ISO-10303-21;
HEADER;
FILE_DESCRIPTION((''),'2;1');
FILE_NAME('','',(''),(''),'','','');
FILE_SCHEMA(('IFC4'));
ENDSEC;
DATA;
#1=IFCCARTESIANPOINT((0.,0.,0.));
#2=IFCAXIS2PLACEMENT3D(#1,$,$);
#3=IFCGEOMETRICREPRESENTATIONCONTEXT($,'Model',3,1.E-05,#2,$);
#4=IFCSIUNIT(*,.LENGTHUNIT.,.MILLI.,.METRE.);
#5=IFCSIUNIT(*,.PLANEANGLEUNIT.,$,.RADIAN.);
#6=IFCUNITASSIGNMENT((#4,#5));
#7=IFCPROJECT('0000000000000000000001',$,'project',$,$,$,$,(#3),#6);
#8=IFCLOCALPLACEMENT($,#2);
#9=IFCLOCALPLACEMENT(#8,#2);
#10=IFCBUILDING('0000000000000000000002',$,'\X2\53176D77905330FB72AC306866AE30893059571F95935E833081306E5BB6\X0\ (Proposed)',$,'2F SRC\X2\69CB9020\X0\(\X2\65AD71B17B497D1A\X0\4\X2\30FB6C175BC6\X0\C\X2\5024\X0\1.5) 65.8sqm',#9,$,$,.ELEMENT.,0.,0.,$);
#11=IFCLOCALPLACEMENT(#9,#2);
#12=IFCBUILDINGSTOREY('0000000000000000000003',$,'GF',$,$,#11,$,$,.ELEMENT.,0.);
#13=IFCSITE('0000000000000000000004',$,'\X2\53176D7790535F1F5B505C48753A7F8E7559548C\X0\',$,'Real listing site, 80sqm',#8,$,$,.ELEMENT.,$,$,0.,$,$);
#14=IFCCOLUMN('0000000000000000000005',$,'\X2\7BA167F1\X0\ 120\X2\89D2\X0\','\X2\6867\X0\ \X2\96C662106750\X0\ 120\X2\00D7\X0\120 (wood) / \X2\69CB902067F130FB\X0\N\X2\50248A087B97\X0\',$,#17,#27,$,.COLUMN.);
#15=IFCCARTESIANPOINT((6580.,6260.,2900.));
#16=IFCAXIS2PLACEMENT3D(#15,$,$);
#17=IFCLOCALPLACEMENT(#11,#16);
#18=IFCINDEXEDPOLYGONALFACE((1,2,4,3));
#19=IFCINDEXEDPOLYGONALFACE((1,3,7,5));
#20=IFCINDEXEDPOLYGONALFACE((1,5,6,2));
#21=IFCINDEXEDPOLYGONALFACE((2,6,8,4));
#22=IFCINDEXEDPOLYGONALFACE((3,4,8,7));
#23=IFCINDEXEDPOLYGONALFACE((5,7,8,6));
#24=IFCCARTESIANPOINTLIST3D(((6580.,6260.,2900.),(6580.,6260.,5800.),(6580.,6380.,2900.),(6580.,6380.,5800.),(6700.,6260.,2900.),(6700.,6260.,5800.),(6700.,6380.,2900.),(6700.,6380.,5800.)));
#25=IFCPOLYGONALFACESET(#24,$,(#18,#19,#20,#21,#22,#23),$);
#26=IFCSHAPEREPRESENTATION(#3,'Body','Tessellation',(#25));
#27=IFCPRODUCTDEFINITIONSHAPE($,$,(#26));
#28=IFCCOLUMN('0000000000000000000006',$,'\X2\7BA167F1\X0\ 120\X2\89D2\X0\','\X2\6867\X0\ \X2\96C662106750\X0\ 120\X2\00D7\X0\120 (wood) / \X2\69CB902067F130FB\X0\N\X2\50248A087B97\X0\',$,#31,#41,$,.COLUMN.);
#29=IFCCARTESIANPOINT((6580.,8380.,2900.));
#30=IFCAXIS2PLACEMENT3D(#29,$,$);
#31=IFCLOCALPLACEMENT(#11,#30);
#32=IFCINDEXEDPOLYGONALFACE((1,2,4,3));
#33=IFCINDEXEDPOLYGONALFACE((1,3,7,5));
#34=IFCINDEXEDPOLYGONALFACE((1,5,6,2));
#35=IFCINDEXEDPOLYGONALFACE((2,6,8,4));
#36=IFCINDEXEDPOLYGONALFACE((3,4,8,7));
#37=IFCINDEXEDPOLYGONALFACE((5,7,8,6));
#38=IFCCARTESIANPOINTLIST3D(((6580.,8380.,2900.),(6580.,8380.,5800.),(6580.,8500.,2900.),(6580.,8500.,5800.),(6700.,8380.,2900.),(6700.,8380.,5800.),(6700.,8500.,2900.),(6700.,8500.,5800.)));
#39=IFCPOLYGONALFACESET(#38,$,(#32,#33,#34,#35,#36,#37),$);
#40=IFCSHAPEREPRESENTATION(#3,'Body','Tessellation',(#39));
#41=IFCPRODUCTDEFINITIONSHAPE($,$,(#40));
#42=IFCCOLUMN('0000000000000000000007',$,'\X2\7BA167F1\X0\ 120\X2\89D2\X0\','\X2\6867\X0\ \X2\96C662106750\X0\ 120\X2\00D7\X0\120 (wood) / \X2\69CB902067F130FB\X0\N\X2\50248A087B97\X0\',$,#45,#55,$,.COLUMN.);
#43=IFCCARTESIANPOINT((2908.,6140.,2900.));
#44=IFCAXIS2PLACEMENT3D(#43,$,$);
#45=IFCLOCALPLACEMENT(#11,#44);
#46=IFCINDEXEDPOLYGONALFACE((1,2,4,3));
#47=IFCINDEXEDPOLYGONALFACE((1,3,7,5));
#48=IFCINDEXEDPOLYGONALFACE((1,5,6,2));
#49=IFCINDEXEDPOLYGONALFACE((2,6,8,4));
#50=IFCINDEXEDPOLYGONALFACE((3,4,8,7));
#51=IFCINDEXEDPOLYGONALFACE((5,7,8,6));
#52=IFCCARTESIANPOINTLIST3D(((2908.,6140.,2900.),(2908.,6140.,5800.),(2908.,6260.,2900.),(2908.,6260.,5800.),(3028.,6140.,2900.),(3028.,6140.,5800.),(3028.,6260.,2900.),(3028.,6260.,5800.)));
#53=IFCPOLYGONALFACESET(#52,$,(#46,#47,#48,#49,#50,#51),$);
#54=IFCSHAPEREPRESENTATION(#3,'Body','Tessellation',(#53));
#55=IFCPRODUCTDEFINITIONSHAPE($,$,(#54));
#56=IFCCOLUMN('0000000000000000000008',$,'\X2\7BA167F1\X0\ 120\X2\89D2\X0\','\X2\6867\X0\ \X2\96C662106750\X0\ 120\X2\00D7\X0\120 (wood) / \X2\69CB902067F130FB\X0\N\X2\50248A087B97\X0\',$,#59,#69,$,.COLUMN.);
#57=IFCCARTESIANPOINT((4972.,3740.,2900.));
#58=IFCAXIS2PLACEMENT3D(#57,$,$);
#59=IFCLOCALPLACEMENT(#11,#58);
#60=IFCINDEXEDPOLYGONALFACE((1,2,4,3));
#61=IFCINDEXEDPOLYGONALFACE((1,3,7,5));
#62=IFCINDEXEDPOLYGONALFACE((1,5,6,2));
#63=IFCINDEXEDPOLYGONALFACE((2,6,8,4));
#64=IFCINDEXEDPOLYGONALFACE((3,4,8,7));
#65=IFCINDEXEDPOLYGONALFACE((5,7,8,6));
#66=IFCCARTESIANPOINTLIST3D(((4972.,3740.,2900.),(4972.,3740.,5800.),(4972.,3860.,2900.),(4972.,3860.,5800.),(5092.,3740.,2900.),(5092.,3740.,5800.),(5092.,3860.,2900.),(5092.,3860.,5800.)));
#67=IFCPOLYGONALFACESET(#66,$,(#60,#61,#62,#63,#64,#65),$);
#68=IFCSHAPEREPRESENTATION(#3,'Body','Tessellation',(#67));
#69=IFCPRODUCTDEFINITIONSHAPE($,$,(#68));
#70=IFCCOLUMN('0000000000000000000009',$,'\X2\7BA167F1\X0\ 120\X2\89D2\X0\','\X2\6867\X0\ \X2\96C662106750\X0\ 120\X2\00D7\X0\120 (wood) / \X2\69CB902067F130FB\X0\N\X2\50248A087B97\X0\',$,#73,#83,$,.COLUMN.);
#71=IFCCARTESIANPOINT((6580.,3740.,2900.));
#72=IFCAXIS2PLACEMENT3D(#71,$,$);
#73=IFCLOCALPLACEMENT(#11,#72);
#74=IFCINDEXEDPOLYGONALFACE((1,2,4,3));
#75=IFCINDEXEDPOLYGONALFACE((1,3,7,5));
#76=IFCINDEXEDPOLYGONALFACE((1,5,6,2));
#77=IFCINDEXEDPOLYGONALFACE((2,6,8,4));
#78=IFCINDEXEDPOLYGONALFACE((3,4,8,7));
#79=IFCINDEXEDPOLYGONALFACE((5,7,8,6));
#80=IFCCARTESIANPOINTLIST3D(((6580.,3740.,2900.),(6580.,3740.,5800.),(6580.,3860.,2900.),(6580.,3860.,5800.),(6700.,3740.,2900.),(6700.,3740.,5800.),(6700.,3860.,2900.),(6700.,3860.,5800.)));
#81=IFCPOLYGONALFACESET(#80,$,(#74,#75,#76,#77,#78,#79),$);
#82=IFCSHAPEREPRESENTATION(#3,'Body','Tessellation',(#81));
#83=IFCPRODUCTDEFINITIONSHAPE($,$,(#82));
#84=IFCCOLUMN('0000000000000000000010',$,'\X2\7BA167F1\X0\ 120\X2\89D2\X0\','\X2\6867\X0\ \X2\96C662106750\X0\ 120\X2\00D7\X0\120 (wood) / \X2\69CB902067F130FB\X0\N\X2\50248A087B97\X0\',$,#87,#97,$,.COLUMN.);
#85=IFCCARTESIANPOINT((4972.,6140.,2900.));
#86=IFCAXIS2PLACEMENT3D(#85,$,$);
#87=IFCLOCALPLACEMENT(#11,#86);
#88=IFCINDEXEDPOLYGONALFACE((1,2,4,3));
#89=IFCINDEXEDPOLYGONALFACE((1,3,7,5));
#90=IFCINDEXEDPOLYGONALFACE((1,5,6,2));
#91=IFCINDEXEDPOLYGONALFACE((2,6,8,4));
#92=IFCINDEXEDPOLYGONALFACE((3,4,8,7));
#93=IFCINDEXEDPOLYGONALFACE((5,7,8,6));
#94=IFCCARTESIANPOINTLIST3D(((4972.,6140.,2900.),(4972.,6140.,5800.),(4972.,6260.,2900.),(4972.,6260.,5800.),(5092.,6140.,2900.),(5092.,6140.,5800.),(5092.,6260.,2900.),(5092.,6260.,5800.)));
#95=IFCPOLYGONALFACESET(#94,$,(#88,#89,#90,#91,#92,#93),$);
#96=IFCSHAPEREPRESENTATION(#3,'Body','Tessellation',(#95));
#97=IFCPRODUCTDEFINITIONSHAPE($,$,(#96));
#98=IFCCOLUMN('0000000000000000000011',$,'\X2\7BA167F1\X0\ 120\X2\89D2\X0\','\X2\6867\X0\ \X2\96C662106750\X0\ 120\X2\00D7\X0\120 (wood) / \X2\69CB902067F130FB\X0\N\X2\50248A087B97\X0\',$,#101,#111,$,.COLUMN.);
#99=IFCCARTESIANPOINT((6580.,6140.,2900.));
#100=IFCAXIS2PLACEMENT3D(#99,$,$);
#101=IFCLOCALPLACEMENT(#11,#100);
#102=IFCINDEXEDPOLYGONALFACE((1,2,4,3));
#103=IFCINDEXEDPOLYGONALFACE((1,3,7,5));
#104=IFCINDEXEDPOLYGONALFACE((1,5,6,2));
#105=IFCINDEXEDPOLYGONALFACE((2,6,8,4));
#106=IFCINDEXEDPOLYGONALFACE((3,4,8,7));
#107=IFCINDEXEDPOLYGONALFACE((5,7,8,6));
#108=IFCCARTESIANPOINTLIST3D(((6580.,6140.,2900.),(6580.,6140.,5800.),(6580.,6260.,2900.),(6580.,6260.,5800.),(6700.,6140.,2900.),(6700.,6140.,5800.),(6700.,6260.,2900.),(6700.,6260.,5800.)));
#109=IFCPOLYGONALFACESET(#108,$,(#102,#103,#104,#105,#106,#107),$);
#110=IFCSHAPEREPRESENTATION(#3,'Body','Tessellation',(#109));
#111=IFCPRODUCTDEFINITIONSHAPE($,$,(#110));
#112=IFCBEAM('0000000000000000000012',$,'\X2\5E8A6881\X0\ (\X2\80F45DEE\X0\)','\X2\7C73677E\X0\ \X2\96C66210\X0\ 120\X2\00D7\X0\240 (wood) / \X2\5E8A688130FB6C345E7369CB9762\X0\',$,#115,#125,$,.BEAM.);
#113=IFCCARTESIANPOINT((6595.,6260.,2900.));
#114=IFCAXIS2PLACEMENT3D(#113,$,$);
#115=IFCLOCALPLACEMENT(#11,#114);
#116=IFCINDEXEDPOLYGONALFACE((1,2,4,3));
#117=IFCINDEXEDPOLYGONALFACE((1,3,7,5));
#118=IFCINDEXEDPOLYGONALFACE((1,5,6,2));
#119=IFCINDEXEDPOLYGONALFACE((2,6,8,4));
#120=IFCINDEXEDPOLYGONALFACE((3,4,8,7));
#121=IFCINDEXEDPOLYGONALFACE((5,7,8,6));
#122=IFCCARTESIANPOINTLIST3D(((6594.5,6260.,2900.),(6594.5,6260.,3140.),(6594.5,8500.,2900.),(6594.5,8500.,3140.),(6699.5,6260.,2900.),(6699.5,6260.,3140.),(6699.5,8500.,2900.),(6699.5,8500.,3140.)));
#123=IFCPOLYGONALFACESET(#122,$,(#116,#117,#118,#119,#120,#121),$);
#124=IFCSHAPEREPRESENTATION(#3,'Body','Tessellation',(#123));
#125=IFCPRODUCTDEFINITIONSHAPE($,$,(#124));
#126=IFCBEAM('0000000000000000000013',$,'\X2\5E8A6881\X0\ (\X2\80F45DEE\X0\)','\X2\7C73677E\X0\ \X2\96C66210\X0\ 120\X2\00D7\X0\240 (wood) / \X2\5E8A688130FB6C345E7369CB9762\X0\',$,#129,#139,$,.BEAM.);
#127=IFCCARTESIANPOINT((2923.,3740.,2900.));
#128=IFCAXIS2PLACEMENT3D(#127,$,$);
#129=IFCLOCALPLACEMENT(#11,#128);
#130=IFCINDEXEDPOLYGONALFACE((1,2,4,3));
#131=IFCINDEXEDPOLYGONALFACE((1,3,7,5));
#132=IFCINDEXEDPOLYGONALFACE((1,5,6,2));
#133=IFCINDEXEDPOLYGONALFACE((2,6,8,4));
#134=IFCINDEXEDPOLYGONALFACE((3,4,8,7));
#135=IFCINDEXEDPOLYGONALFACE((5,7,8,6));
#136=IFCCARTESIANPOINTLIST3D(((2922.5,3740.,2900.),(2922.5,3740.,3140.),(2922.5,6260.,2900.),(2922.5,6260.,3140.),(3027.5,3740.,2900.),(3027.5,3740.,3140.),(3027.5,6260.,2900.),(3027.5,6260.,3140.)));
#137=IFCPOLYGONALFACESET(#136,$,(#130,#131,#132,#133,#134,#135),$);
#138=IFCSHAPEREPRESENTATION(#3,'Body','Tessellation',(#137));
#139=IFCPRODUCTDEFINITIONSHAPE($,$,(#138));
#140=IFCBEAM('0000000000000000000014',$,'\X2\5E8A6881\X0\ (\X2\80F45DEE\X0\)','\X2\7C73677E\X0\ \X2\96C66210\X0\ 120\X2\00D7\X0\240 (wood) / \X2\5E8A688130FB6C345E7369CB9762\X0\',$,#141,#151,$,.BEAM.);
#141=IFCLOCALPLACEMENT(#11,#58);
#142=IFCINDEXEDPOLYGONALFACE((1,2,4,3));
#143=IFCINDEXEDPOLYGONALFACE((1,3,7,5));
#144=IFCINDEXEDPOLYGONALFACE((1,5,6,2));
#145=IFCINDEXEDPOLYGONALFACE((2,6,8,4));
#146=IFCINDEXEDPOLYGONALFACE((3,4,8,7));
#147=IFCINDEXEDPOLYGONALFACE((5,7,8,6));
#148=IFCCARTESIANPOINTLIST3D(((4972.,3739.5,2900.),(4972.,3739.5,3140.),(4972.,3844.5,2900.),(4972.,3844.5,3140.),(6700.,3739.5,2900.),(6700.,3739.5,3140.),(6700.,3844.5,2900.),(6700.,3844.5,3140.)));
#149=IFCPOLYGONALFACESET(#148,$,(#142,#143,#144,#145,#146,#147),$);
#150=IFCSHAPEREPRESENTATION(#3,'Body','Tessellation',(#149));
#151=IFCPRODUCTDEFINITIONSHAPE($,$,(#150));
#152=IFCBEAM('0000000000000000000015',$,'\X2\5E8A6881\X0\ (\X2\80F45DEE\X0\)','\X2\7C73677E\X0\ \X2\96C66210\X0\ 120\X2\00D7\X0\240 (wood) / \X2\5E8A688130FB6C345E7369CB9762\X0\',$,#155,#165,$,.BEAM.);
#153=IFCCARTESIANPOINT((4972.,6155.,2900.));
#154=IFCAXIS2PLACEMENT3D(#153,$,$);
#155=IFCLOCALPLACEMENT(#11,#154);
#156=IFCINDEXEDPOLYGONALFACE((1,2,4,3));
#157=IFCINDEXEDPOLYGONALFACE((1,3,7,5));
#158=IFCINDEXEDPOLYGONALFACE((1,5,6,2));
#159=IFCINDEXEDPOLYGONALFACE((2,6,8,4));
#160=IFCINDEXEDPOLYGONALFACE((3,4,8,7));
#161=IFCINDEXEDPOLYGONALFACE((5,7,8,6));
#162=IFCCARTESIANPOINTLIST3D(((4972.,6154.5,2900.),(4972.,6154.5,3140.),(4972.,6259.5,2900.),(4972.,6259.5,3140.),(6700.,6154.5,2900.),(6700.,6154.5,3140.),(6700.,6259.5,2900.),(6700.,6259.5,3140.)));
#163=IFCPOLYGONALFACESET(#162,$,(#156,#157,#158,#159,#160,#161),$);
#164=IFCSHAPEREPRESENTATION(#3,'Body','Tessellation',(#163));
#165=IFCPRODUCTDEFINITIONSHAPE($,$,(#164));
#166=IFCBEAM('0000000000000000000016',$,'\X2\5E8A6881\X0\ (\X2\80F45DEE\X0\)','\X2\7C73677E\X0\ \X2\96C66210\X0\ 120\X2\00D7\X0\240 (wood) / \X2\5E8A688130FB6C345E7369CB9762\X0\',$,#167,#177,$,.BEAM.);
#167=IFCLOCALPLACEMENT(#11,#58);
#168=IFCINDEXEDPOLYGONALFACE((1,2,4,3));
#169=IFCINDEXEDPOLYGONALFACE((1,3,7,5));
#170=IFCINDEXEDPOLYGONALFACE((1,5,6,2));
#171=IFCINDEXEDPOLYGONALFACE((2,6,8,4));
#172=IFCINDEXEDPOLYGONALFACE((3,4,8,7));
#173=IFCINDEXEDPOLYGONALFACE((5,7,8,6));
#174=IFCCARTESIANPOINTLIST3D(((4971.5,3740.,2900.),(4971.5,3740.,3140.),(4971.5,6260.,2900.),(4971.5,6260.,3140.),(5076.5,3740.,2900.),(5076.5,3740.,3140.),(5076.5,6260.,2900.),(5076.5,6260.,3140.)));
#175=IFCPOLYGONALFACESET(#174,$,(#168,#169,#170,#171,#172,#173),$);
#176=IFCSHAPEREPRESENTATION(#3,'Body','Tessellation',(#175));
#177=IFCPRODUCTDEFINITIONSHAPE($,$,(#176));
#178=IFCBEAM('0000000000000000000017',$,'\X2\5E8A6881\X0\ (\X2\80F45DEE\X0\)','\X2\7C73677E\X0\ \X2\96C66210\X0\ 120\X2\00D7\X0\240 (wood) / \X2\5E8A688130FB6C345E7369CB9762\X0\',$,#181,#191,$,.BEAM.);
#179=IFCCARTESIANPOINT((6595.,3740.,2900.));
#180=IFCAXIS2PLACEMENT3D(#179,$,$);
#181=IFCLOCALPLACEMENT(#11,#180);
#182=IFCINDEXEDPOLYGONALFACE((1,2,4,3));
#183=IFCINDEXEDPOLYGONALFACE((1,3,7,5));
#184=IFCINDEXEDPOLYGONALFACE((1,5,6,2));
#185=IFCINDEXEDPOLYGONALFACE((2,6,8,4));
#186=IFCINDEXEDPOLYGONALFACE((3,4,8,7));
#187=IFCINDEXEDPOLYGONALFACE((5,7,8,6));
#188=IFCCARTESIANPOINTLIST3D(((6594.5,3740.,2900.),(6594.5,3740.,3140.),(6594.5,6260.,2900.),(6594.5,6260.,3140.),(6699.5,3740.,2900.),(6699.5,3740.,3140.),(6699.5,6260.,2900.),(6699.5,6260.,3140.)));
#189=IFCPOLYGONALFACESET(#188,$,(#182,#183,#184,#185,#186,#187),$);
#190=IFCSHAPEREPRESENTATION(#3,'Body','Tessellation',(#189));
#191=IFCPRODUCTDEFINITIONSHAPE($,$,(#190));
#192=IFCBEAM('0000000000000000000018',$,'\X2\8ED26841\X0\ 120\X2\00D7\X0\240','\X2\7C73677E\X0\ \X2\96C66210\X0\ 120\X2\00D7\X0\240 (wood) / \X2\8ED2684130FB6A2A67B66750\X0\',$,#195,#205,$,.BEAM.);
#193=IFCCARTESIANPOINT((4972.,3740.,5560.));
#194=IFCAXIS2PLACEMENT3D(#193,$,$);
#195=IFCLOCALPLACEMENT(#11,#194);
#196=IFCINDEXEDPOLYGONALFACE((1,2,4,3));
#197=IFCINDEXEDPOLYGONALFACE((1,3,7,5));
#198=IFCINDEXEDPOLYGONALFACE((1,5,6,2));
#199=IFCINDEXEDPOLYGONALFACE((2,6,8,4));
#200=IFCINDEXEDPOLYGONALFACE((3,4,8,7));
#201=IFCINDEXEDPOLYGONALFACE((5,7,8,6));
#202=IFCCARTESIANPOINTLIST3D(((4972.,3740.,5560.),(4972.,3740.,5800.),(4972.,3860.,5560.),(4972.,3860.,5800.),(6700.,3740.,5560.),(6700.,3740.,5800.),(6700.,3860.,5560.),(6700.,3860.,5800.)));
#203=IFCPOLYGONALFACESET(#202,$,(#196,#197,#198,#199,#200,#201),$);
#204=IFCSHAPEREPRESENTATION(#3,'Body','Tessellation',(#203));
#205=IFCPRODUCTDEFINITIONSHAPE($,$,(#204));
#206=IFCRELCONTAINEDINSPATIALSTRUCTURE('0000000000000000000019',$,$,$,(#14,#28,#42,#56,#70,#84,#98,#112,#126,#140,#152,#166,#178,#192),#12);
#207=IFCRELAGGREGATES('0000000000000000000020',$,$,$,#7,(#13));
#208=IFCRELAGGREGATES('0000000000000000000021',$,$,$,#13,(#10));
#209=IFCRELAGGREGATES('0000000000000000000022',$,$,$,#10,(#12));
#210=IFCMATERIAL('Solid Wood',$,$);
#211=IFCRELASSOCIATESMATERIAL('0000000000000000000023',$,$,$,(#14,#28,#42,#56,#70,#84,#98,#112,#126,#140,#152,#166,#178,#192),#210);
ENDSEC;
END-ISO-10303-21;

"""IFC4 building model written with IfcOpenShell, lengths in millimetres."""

from ifc_helpers import new_model, si_unit, frame, frame_2d, origin, place, context, project, spatial, rectangle, extrude, material, element, save


model = new_model("IFC4")

# Units and contexts
model_context = context("Model", 3, precision=1e-05, world=origin())
ifc_project = project(units=[si_unit("LENGTHUNIT", "METRE", prefix="MILLI"), si_unit("PLANEANGLEUNIT", "RADIAN")], contexts=[model_context])

# Site, building, storey
site_placement = place(None, origin())
site = spatial("IfcSite", under=ifc_project, at=site_placement, Name="北海道弟子屈町美留和", ObjectType="Real listing site, 80sqm", CompositionType="ELEMENT", RefElevation=0.0)
building_placement = place(site_placement, origin())
building = spatial("IfcBuilding", under=site, at=building_placement, Name="北海道・犬と暮らす土間広めの家 (Proposed)", ObjectType="2F SRC構造(断熱等級4・気密C値1.5) 65.8sqm", CompositionType="ELEMENT", ElevationOfRefHeight=0.0, ElevationOfTerrain=0.0)
storey_placement = place(building_placement, origin())
storey = spatial("IfcBuildingStorey", under=building, at=storey_placement, Name="GF", CompositionType="ELEMENT", Elevation=0.0)

# Columns
ifc_material_1 = material(Name="Solid Wood")
column_1_placement = place(storey_placement, frame((6580.0, 6260.0, 2900.0)))
element("IfcColumn", 1, at=column_1_placement, inside=storey, material=ifc_material_1, Name="管柱 120角", Description="桧 集成材 120×120 (wood) / 構造柱・N値計算", PredefinedType="COLUMN", context=model_context, shape_type="SweptSolid", body=[
    extrude(rectangle(XDim=120.0, YDim=120.0, at=frame_2d((60.0, 60.0))), frame((6580.0, 6260.0, 2900.0)), (0.0, 0.0, 1.0), 2900.0),
])
column_2_placement = place(storey_placement, frame((6580.0, 8380.0, 2900.0)))
element("IfcColumn", 2, at=column_2_placement, inside=storey, material=ifc_material_1, Name="管柱 120角", Description="桧 集成材 120×120 (wood) / 構造柱・N値計算", PredefinedType="COLUMN", context=model_context, shape_type="SweptSolid", body=[
    extrude(rectangle(XDim=120.0, YDim=120.0, at=frame_2d((60.0, 60.0))), frame((6580.0, 8380.0, 2900.0)), (0.0, 0.0, 1.0), 2900.0),
])
column_3_placement = place(storey_placement, frame((2908.0, 6140.0, 2900.0)))
element("IfcColumn", 3, at=column_3_placement, inside=storey, material=ifc_material_1, Name="管柱 120角", Description="桧 集成材 120×120 (wood) / 構造柱・N値計算", PredefinedType="COLUMN", context=model_context, shape_type="SweptSolid", body=[
    extrude(rectangle(XDim=120.0, YDim=120.0, at=frame_2d((60.0, 60.0))), frame((2908.0, 6140.0, 2900.0)), (0.0, 0.0, 1.0), 2900.0),
])
column_4_placement = place(storey_placement, frame((4972.0, 3740.0, 2900.0)))
element("IfcColumn", 4, at=column_4_placement, inside=storey, material=ifc_material_1, Name="管柱 120角", Description="桧 集成材 120×120 (wood) / 構造柱・N値計算", PredefinedType="COLUMN", context=model_context, shape_type="SweptSolid", body=[
    extrude(rectangle(XDim=120.0, YDim=120.0, at=frame_2d((60.0, 60.0))), frame((4972.0, 3740.0, 2900.0)), (0.0, 0.0, 1.0), 2900.0),
])
column_5_placement = place(storey_placement, frame((6580.0, 3740.0, 2900.0)))
element("IfcColumn", 5, at=column_5_placement, inside=storey, material=ifc_material_1, Name="管柱 120角", Description="桧 集成材 120×120 (wood) / 構造柱・N値計算", PredefinedType="COLUMN", context=model_context, shape_type="SweptSolid", body=[
    extrude(rectangle(XDim=120.0, YDim=120.0, at=frame_2d((60.0, 60.0))), frame((6580.0, 3740.0, 2900.0)), (0.0, 0.0, 1.0), 2900.0),
])
column_6_placement = place(storey_placement, frame((4972.0, 6140.0, 2900.0)))
element("IfcColumn", 6, at=column_6_placement, inside=storey, material=ifc_material_1, Name="管柱 120角", Description="桧 集成材 120×120 (wood) / 構造柱・N値計算", PredefinedType="COLUMN", context=model_context, shape_type="SweptSolid", body=[
    extrude(rectangle(XDim=120.0, YDim=120.0, at=frame_2d((60.0, 60.0))), frame((4972.0, 6140.0, 2900.0)), (0.0, 0.0, 1.0), 2900.0),
])
column_7_placement = place(storey_placement, frame((6580.0, 6140.0, 2900.0)))
element("IfcColumn", 7, at=column_7_placement, inside=storey, material=ifc_material_1, Name="管柱 120角", Description="桧 集成材 120×120 (wood) / 構造柱・N値計算", PredefinedType="COLUMN", context=model_context, shape_type="SweptSolid", body=[
    extrude(rectangle(XDim=120.0, YDim=120.0, at=frame_2d((60.0, 60.0))), frame((6580.0, 6140.0, 2900.0)), (0.0, 0.0, 1.0), 2900.0),
])

# Beams
beam_1_placement = place(storey_placement, frame((6595.0, 6260.0, 2900.0)))
element("IfcBeam", 8, at=beam_1_placement, inside=storey, material=ifc_material_1, Name="床梁 (胴差)", Description="米松 集成 120×240 (wood) / 床梁・水平構面", PredefinedType="BEAM", context=model_context, shape_type="SweptSolid", body=[
    extrude(rectangle(XDim=105.0, YDim=2240.0, at=frame_2d((52.0, 1120.0))), frame((6595.0, 6260.0, 2900.0)), (0.0, 0.0, 1.0), 240.0),
])
beam_2_placement = place(storey_placement, frame((2923.0, 3740.0, 2900.0)))
element("IfcBeam", 9, at=beam_2_placement, inside=storey, material=ifc_material_1, Name="床梁 (胴差)", Description="米松 集成 120×240 (wood) / 床梁・水平構面", PredefinedType="BEAM", context=model_context, shape_type="SweptSolid", body=[
    extrude(rectangle(XDim=105.0, YDim=2520.0, at=frame_2d((52.0, 1260.0))), frame((2923.0, 3740.0, 2900.0)), (0.0, 0.0, 1.0), 240.0),
])
beam_3_placement = place(storey_placement, frame((4972.0, 3740.0, 2900.0)))
element("IfcBeam", 10, at=beam_3_placement, inside=storey, material=ifc_material_1, Name="床梁 (胴差)", Description="米松 集成 120×240 (wood) / 床梁・水平構面", PredefinedType="BEAM", context=model_context, shape_type="SweptSolid", body=[
    extrude(rectangle(XDim=1728.0, YDim=105.0, at=frame_2d((864.0, 52.0))), frame((4972.0, 3740.0, 2900.0)), (0.0, 0.0, 1.0), 240.0),
])
beam_4_placement = place(storey_placement, frame((4972.0, 6155.0, 2900.0)))
element("IfcBeam", 11, at=beam_4_placement, inside=storey, material=ifc_material_1, Name="床梁 (胴差)", Description="米松 集成 120×240 (wood) / 床梁・水平構面", PredefinedType="BEAM", context=model_context, shape_type="SweptSolid", body=[
    extrude(rectangle(XDim=1728.0, YDim=105.0, at=frame_2d((864.0, 52.0))), frame((4972.0, 6155.0, 2900.0)), (0.0, 0.0, 1.0), 240.0),
])
beam_5_placement = place(storey_placement, frame((4972.0, 3740.0, 2900.0)))
element("IfcBeam", 12, at=beam_5_placement, inside=storey, material=ifc_material_1, Name="床梁 (胴差)", Description="米松 集成 120×240 (wood) / 床梁・水平構面", PredefinedType="BEAM", context=model_context, shape_type="SweptSolid", body=[
    extrude(rectangle(XDim=105.0, YDim=2520.0, at=frame_2d((52.0, 1260.0))), frame((4972.0, 3740.0, 2900.0)), (0.0, 0.0, 1.0), 240.0),
])
beam_6_placement = place(storey_placement, frame((6595.0, 3740.0, 2900.0)))
element("IfcBeam", 13, at=beam_6_placement, inside=storey, material=ifc_material_1, Name="床梁 (胴差)", Description="米松 集成 120×240 (wood) / 床梁・水平構面", PredefinedType="BEAM", context=model_context, shape_type="SweptSolid", body=[
    extrude(rectangle(XDim=105.0, YDim=2520.0, at=frame_2d((52.0, 1260.0))), frame((6595.0, 3740.0, 2900.0)), (0.0, 0.0, 1.0), 240.0),
])
beam_7_placement = place(storey_placement, frame((4972.0, 3740.0, 5560.0)))
element("IfcBeam", 14, at=beam_7_placement, inside=storey, material=ifc_material_1, Name="軒桁 120×240", Description="米松 集成 120×240 (wood) / 軒桁・横架材", PredefinedType="BEAM", context=model_context, shape_type="SweptSolid", body=[
    extrude(rectangle(XDim=1728.0, YDim=120.0, at=frame_2d((864.0, 60.0))), frame((4972.0, 3740.0, 5560.0)), (0.0, 0.0, 1.0), 240.0),
])

save(model, "model.ifc")
